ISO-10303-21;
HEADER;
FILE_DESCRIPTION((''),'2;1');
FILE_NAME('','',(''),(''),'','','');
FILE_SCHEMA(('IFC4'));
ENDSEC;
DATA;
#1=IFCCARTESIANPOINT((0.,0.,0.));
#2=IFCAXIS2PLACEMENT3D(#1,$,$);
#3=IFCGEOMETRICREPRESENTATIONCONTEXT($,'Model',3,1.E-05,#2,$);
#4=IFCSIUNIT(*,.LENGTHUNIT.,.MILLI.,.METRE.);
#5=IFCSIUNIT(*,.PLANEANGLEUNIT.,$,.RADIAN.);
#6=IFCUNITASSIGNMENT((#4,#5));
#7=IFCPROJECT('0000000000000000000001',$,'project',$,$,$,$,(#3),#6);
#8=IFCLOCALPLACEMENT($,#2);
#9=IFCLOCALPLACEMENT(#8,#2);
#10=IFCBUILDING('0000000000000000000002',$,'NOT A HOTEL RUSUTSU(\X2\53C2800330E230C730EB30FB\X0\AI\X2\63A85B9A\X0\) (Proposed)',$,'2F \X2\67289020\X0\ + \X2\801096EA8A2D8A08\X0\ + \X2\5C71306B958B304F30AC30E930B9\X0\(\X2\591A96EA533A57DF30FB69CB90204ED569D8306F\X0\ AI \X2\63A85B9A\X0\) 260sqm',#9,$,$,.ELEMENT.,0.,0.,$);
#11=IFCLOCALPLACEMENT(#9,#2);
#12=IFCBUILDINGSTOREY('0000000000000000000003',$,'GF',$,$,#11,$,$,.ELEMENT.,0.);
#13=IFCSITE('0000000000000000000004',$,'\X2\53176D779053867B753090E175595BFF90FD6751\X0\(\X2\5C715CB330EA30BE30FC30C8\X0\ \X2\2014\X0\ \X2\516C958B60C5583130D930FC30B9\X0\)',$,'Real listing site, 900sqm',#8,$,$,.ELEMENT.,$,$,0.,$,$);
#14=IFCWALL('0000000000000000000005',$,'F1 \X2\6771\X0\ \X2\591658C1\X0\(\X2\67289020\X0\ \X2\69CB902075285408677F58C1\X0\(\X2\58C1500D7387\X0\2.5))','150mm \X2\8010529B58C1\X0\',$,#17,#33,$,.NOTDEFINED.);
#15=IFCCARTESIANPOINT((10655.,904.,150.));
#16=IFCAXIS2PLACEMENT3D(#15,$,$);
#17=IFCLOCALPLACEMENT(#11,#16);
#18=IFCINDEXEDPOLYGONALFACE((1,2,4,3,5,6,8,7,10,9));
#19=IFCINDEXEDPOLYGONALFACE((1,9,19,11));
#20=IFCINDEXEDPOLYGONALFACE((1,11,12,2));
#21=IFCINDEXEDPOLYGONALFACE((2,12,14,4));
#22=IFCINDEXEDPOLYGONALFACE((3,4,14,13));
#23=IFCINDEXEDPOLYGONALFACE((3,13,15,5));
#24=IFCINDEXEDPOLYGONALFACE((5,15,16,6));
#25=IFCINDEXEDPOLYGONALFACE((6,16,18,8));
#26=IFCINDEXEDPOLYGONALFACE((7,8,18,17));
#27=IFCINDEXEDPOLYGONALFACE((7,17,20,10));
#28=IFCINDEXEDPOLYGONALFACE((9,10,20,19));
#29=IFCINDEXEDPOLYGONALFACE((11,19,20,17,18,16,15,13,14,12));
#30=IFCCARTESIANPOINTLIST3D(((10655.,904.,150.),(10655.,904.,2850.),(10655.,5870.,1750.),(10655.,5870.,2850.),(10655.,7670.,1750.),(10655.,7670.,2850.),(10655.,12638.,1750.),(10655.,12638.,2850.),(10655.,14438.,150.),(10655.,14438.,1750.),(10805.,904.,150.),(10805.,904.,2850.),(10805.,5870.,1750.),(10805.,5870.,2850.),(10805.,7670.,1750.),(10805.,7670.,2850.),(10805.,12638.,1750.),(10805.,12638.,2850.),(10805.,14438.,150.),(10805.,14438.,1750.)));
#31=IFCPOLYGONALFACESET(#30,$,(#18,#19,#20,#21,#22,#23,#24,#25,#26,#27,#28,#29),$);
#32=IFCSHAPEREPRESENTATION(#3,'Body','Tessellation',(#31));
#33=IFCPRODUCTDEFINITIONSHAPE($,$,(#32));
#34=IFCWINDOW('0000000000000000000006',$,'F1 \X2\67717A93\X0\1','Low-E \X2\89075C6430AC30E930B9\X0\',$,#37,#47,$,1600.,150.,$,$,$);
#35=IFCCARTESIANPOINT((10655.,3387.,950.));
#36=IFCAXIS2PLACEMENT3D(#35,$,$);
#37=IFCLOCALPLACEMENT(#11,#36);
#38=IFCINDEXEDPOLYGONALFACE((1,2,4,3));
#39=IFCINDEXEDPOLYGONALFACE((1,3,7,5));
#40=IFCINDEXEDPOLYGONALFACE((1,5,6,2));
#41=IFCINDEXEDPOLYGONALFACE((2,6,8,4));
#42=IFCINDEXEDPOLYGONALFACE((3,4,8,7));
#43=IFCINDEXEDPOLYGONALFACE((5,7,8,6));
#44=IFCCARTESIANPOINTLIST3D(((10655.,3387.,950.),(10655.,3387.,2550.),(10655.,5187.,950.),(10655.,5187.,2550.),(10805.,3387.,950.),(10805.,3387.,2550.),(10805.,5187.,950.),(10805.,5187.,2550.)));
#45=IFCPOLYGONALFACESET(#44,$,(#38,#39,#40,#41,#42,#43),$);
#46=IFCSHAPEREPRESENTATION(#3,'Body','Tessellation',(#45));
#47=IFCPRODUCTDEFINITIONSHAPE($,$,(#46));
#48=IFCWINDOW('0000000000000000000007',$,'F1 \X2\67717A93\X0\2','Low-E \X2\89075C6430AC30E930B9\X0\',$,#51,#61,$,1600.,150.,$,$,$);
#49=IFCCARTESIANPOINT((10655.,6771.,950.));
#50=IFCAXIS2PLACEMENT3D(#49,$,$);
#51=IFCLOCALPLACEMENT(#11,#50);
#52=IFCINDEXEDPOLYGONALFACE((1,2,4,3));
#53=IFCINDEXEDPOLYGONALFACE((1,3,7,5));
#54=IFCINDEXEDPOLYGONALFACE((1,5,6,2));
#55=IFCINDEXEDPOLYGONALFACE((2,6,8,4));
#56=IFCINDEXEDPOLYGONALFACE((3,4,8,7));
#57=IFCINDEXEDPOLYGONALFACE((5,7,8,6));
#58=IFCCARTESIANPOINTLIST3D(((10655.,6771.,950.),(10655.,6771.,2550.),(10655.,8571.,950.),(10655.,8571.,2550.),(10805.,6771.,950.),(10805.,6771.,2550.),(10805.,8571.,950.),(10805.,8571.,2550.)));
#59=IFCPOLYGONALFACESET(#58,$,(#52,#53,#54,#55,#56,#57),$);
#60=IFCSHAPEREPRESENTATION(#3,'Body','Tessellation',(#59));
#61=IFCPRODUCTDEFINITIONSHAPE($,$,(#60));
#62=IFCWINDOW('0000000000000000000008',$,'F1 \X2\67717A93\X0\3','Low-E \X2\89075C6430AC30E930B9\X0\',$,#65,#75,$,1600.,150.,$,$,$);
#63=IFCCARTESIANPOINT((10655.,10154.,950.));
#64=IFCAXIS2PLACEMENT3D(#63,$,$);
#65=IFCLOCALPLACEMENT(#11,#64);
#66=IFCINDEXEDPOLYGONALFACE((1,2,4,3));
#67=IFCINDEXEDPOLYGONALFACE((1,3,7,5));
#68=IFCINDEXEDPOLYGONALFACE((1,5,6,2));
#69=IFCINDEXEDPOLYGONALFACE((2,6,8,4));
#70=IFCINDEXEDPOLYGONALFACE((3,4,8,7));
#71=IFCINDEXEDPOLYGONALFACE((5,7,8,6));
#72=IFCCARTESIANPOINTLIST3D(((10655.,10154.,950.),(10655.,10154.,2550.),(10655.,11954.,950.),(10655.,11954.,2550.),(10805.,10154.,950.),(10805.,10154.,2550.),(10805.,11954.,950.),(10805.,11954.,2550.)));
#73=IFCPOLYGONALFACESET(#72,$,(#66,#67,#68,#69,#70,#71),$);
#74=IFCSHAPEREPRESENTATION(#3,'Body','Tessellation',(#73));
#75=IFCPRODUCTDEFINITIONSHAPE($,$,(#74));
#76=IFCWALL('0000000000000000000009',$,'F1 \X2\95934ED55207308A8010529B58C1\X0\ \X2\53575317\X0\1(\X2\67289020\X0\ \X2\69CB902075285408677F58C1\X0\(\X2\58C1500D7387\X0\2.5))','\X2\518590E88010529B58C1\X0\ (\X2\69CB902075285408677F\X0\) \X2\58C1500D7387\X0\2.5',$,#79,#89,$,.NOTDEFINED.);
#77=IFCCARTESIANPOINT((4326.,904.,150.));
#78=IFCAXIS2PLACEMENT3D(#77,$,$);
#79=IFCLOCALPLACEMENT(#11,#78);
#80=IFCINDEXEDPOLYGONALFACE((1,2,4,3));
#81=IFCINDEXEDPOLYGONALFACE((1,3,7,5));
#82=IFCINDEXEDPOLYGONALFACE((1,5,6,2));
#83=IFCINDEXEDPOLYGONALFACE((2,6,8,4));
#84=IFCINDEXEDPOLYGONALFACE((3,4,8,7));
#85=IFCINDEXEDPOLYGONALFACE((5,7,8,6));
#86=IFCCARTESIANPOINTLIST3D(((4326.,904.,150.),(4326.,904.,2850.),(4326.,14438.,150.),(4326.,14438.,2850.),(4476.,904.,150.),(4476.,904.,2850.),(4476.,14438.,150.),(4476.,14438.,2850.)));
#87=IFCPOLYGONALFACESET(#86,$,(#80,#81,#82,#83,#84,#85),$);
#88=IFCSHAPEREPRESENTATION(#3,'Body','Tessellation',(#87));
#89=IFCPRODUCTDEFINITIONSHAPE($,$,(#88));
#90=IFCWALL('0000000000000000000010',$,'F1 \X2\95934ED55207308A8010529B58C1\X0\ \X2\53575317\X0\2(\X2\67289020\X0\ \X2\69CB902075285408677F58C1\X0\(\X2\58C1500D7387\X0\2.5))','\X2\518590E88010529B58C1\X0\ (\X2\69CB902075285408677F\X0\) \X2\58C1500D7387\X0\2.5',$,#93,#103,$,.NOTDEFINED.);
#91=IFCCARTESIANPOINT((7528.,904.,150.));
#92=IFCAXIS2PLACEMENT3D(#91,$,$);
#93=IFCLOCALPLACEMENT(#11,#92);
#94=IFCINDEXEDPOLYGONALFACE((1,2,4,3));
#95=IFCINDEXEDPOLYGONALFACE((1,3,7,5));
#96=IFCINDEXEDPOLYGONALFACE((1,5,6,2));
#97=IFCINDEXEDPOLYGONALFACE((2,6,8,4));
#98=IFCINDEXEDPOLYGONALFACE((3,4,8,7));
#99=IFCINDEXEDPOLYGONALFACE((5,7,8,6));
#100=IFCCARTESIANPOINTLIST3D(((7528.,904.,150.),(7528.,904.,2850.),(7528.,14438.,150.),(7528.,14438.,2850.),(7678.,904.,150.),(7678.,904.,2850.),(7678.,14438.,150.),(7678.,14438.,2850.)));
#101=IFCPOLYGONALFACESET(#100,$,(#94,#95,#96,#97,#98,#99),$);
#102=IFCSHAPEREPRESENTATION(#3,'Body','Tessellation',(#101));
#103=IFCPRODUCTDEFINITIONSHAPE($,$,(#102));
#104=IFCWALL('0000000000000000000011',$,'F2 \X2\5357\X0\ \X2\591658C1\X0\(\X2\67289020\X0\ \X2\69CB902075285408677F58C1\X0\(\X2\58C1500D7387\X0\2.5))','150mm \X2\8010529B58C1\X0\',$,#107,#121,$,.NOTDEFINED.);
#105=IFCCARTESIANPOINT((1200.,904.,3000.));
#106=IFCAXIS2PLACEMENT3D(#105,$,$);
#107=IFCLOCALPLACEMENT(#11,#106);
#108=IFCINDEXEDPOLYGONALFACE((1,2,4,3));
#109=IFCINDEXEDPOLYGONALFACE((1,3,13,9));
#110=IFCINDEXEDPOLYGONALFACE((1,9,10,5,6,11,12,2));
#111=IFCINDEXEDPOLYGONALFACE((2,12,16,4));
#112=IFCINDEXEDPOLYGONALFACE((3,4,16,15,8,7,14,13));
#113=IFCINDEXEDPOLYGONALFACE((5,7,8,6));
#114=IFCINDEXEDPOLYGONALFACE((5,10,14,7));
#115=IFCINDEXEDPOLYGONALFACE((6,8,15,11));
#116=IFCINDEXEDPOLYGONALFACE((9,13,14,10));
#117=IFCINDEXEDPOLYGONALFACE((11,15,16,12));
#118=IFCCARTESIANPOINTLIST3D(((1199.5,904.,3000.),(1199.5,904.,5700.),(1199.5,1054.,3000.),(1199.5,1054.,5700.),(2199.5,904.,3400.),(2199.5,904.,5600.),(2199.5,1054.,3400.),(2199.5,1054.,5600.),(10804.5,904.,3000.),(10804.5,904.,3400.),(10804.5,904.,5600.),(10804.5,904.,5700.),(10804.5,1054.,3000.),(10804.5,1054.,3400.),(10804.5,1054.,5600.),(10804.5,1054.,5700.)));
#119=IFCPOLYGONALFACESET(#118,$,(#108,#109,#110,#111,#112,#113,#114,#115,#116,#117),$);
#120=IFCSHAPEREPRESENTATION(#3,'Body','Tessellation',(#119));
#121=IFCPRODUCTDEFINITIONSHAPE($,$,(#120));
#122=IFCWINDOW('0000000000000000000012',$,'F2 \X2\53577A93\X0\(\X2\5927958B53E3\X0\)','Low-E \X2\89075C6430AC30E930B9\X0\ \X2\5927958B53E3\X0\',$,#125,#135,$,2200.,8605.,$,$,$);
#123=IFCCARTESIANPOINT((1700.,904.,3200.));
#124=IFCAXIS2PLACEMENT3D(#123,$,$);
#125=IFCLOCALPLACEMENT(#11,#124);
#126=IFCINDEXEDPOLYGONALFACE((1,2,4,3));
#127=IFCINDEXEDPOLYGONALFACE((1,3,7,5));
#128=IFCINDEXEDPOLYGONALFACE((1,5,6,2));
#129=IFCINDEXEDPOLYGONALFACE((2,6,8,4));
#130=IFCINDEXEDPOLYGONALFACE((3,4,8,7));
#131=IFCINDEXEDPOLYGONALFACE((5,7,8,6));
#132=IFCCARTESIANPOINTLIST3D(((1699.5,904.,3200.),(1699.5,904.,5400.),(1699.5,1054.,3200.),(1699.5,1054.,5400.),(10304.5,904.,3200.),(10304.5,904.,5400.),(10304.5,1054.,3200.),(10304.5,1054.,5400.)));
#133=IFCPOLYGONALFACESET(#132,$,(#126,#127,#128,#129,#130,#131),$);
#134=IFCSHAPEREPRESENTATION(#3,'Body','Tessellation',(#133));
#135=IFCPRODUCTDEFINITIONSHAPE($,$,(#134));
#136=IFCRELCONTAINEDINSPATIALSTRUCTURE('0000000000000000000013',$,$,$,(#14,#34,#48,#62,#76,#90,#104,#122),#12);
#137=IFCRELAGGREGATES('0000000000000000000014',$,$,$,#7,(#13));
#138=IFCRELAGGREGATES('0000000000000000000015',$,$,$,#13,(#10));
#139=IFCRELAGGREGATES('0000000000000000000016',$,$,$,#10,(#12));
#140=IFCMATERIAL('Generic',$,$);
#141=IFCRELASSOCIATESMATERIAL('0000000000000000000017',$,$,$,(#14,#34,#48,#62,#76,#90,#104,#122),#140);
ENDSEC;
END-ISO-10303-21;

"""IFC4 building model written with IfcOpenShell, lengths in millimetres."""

from ifc_helpers import new_model, si_unit, frame, frame_2d, origin, place, context, project, spatial, rectangle, extrude, material, element, fill, save


model = new_model("IFC4")

# Units and contexts
model_context = context("Model", 3, precision=1e-05, world=origin())
ifc_project = project(units=[si_unit("LENGTHUNIT", "METRE", prefix="MILLI"), si_unit("PLANEANGLEUNIT", "RADIAN")], contexts=[model_context])

# Site, building, storey
site_placement = place(None, origin())
site = spatial("IfcSite", under=ifc_project, at=site_placement, Name="北海道虻田郡留寿都村(山岳リゾート — 公開情報ベース)", ObjectType="Real listing site, 900sqm", CompositionType="ELEMENT", RefElevation=0.0)
building_placement = place(site_placement, origin())
building = spatial("IfcBuilding", under=site, at=building_placement, Name="NOT A HOTEL RUSUTSU(参考モデル・AI推定) (Proposed)", ObjectType="2F 木造 + 耐雪設計 + 山に開くガラス(多雪区域・構造仕様は AI 推定) 260sqm", CompositionType="ELEMENT", ElevationOfRefHeight=0.0, ElevationOfTerrain=0.0)
storey_placement = place(building_placement, origin())
storey = spatial("IfcBuildingStorey", under=building, at=storey_placement, Name="GF", CompositionType="ELEMENT", Elevation=0.0)

# Wall, openings, windows
ifc_material = material(Name="Generic")
wall_1_placement = place(storey_placement, frame((10655.0, 904.0, 150.0)))
wall_1 = element("IfcWall", 1, at=wall_1_placement, inside=storey, material=ifc_material, Name="F1 東 外壁(木造 構造用合板壁(壁倍率2.5))", Description="150mm 耐力壁", PredefinedType="NOTDEFINED", context=model_context, shape_type="SweptSolid", body=[
    extrude(rectangle(XDim=150.0, YDim=13534.0, at=frame_2d((75.0, 6767.0))), frame((10655.0, 904.0, 150.0)), (0.0, 0.0, 1.0), 2700.0),
])
opening_1_placement = place(storey_placement, frame((10655.0, 3387.0, 950.0)))
opening_1 = element("IfcOpeningElement", 2, at=opening_1_placement, cuts=wall_1, PredefinedType="NOTDEFINED", context=model_context, shape_type="SweptSolid", body=[
    extrude(rectangle(XDim=150.0, YDim=1800.0, at=frame_2d((75.0, 900.0))), frame((10655.0, 3387.0, 950.0)), (0.0, 0.0, 1.0), 1600.0),
])
opening_2_placement = place(storey_placement, frame((10655.0, 6771.0, 950.0)))
opening_2 = element("IfcOpeningElement", 3, at=opening_2_placement, cuts=wall_1, PredefinedType="NOTDEFINED", context=model_context, shape_type="SweptSolid", body=[
    extrude(rectangle(XDim=150.0, YDim=1800.0, at=frame_2d((75.0, 900.0))), frame((10655.0, 6771.0, 950.0)), (0.0, 0.0, 1.0), 1600.0),
])
opening_3_placement = place(storey_placement, frame((10655.0, 10154.0, 950.0)))
opening_3 = element("IfcOpeningElement", 4, at=opening_3_placement, cuts=wall_1, PredefinedType="NOTDEFINED", context=model_context, shape_type="SweptSolid", body=[
    extrude(rectangle(XDim=150.0, YDim=1800.0, at=frame_2d((75.0, 900.0))), frame((10655.0, 10154.0, 950.0)), (0.0, 0.0, 1.0), 1600.0),
])
window_1_placement = place(storey_placement, frame((10655.0, 3387.0, 950.0)))
window_1 = element("IfcWindow", 5, at=window_1_placement, inside=storey, material=ifc_material, Name="F1 東窓1", Description="Low-E 複層ガラス", OverallHeight=1600.0, OverallWidth=150.0, context=model_context, shape_type="SweptSolid", body=[
    extrude(rectangle(XDim=150.0, YDim=1800.0, at=frame_2d((75.0, 900.0))), frame((10655.0, 3387.0, 950.0)), (0.0, 0.0, 1.0), 1600.0),
])
fill(opening_1, window_1)
window_2_placement = place(storey_placement, frame((10655.0, 6771.0, 950.0)))
window_2 = element("IfcWindow", 6, at=window_2_placement, inside=storey, material=ifc_material, Name="F1 東窓2", Description="Low-E 複層ガラス", OverallHeight=1600.0, OverallWidth=150.0, context=model_context, shape_type="SweptSolid", body=[
    extrude(rectangle(XDim=150.0, YDim=1800.0, at=frame_2d((75.0, 900.0))), frame((10655.0, 6771.0, 950.0)), (0.0, 0.0, 1.0), 1600.0),
])
fill(opening_2, window_2)
window_3_placement = place(storey_placement, frame((10655.0, 10154.0, 950.0)))
window_3 = element("IfcWindow", 7, at=window_3_placement, inside=storey, material=ifc_material, Name="F1 東窓3", Description="Low-E 複層ガラス", OverallHeight=1600.0, OverallWidth=150.0, context=model_context, shape_type="SweptSolid", body=[
    extrude(rectangle(XDim=150.0, YDim=1800.0, at=frame_2d((75.0, 900.0))), frame((10655.0, 10154.0, 950.0)), (0.0, 0.0, 1.0), 1600.0),
])
fill(opening_3, window_3)

# Walls
wall_2_placement = place(storey_placement, frame((4326.0, 904.0, 150.0)))
element("IfcWall", 8, at=wall_2_placement, inside=storey, material=ifc_material, Name="F1 間仕切り耐力壁 南北1(木造 構造用合板壁(壁倍率2.5))", Description="内部耐力壁 (構造用合板) 壁倍率2.5", PredefinedType="NOTDEFINED", context=model_context, shape_type="SweptSolid", body=[
    extrude(rectangle(XDim=150.0, YDim=13534.0, at=frame_2d((75.0, 6767.0))), frame((4326.0, 904.0, 150.0)), (0.0, 0.0, 1.0), 2700.0),
])
wall_3_placement = place(storey_placement, frame((7528.0, 904.0, 150.0)))
element("IfcWall", 9, at=wall_3_placement, inside=storey, material=ifc_material, Name="F1 間仕切り耐力壁 南北2(木造 構造用合板壁(壁倍率2.5))", Description="内部耐力壁 (構造用合板) 壁倍率2.5", PredefinedType="NOTDEFINED", context=model_context, shape_type="SweptSolid", body=[
    extrude(rectangle(XDim=150.0, YDim=13534.0, at=frame_2d((75.0, 6767.0))), frame((7528.0, 904.0, 150.0)), (0.0, 0.0, 1.0), 2700.0),
])

# Wall, opening, window
wall_4_placement = place(storey_placement, frame((1200.0, 904.0, 3000.0)))
wall_4 = element("IfcWall", 10, at=wall_4_placement, inside=storey, material=ifc_material, Name="F2 南 外壁(木造 構造用合板壁(壁倍率2.5))", Description="150mm 耐力壁", PredefinedType="NOTDEFINED", context=model_context, shape_type="SweptSolid", body=[
    extrude(rectangle(XDim=9605.0, YDim=150.0, at=frame_2d((4802.0, 75.0))), frame((1200.0, 904.0, 3000.0)), (0.0, 0.0, 1.0), 2700.0),
])
opening_4_placement = place(storey_placement, frame((1700.0, 904.0, 3200.0)))
opening_4 = element("IfcOpeningElement", 11, at=opening_4_placement, cuts=wall_4, PredefinedType="NOTDEFINED", context=model_context, shape_type="SweptSolid", body=[
    extrude(rectangle(XDim=8605.0, YDim=150.0, at=frame_2d((4302.0, 75.0))), frame((1700.0, 904.0, 3200.0)), (0.0, 0.0, 1.0), 2200.0),
])
window_4_placement = place(storey_placement, frame((1700.0, 904.0, 3200.0)))
window_4 = element("IfcWindow", 12, at=window_4_placement, inside=storey, material=ifc_material, Name="F2 南窓(大開口)", Description="Low-E 複層ガラス 大開口", OverallHeight=2200.0, OverallWidth=8605.0, context=model_context, shape_type="SweptSolid", body=[
    extrude(rectangle(XDim=8605.0, YDim=150.0, at=frame_2d((4302.0, 75.0))), frame((1700.0, 904.0, 3200.0)), (0.0, 0.0, 1.0), 2200.0),
])
fill(opening_4, window_4)

save(model, "model.ifc")
